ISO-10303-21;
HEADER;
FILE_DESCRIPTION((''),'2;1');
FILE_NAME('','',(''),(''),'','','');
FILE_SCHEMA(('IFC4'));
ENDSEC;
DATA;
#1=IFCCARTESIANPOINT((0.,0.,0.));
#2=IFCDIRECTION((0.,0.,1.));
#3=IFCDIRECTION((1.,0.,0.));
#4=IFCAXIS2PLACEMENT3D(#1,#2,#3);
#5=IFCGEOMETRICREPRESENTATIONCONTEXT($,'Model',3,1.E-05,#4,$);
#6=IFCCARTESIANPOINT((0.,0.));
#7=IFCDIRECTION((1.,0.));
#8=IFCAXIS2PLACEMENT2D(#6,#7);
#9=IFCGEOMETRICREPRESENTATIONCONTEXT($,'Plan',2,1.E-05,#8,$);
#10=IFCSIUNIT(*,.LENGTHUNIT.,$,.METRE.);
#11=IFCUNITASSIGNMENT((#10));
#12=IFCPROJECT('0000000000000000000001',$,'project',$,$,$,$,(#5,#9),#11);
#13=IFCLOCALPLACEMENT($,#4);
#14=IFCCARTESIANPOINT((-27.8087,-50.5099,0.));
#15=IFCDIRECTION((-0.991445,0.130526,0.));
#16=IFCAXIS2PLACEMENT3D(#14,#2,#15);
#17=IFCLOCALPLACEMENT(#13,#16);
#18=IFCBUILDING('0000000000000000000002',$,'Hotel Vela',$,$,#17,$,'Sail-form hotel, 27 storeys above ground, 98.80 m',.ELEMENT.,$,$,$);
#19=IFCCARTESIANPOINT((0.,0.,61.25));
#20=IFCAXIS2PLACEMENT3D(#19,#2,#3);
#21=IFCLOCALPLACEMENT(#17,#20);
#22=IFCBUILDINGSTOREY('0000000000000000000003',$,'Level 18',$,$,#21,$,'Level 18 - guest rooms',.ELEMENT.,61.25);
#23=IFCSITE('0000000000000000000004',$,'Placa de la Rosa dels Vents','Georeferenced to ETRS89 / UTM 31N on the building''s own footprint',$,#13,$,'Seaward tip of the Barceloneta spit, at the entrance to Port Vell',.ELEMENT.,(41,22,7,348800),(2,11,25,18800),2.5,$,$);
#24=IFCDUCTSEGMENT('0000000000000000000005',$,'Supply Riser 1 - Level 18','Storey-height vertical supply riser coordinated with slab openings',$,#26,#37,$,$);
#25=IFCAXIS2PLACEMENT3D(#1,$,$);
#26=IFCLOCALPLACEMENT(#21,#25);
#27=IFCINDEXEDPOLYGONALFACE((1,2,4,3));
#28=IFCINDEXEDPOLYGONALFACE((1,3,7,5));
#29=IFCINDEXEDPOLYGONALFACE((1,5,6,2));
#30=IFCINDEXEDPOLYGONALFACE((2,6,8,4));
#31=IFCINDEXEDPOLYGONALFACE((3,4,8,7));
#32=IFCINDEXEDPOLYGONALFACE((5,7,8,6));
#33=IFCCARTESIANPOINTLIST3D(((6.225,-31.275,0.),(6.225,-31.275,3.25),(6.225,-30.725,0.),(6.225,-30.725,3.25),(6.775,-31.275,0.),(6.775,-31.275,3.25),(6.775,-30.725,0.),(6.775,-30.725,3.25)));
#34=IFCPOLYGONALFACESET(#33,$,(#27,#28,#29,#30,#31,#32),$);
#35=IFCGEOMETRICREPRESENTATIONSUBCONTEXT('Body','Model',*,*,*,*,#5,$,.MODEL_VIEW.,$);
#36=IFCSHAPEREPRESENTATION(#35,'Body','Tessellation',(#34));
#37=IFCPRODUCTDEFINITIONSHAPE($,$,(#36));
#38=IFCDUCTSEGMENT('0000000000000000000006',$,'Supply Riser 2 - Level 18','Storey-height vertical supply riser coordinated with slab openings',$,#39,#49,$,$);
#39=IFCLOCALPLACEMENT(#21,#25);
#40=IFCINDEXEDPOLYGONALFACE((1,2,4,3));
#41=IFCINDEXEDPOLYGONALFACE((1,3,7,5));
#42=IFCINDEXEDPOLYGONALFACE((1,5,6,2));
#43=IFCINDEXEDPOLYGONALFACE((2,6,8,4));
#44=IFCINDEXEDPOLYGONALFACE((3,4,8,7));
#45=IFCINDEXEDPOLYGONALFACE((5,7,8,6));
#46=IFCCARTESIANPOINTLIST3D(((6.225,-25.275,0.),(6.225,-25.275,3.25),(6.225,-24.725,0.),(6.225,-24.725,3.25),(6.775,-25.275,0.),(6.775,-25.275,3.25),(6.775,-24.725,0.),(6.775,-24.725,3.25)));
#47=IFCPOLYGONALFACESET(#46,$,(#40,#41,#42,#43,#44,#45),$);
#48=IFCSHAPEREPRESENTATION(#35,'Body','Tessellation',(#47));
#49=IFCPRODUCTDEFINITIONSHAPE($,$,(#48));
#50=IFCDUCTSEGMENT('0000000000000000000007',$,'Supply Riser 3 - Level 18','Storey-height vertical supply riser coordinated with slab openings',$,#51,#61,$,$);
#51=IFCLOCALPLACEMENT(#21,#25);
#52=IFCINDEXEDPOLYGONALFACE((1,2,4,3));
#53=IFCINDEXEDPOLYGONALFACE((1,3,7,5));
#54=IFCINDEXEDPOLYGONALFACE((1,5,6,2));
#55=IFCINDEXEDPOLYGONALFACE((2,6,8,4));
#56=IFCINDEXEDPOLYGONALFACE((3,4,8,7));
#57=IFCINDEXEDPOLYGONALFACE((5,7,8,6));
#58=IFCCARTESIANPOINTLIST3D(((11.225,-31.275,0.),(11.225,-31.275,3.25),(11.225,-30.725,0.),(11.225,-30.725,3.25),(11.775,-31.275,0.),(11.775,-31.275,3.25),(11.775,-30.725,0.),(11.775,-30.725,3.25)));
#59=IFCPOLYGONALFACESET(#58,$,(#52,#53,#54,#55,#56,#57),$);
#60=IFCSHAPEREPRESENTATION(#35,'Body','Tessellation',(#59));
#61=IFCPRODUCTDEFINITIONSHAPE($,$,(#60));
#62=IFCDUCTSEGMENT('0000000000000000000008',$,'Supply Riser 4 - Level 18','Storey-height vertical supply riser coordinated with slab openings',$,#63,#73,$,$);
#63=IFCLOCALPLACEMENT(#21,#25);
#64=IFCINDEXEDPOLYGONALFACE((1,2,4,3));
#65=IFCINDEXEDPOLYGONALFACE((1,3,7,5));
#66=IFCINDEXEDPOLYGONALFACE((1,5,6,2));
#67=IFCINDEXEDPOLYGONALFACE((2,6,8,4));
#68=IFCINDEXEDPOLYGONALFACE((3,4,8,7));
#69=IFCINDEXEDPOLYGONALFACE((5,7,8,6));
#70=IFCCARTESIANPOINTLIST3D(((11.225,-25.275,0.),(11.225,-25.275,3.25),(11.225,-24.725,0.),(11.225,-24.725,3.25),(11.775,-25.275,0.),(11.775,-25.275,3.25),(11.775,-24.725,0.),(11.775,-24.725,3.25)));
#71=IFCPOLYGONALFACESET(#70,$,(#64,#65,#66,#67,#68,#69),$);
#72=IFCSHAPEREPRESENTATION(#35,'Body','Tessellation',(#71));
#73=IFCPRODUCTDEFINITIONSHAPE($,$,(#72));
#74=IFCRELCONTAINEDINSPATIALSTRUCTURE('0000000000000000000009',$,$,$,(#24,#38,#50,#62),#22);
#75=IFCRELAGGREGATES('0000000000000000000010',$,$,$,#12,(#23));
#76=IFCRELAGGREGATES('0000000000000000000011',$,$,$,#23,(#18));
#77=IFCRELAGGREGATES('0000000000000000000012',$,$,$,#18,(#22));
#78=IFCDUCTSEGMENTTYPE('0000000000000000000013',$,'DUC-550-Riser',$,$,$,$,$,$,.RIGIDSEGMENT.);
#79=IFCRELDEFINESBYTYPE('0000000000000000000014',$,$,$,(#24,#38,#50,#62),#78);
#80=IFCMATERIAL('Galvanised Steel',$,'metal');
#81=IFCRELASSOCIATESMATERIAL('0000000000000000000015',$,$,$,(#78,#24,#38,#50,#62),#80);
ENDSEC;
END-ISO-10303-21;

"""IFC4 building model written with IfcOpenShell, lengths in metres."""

from ifc_helpers import new_model, si_unit, frame, origin_with_axes, origin_2d_with_axis, place, context, subcontext, project, spatial, line, indexed_curve, outline, extrude, material, type_object, element, save


model = new_model("IFC4")

# Units and contexts
model_context = context("Model", 3, precision=1e-05, world=origin_with_axes())
plan_context = context("Plan", 2, precision=1e-05, world=origin_2d_with_axis())
body_context = subcontext(model_context, "Body", "Model", "MODEL_VIEW")
ifc_project = project(units=[si_unit("LENGTHUNIT", "METRE")], contexts=[model_context, plan_context])

# Site, building, storey
site_placement = place(None, origin_with_axes())
site = spatial("IfcSite", under=ifc_project, at=site_placement, Name="Placa de la Rosa dels Vents", Description="Georeferenced to ETRS89 / UTM 31N on the building's own footprint", LongName="Seaward tip of the Barceloneta spit, at the entrance to Port Vell", CompositionType="ELEMENT", RefLatitude=(41, 22, 7, 348800), RefLongitude=(2, 11, 25, 18800), RefElevation=2.5)
building_placement = place(site_placement, frame((-27.8087, -50.5099, 0.0), z_axis=(0.0, 0.0, 1.0), x_axis=(-0.991445, 0.130526, 0.0)))
building = spatial("IfcBuilding", under=site, at=building_placement, Name="Hotel Vela", LongName="Sail-form hotel, 27 storeys above ground, 98.80 m", CompositionType="ELEMENT")
storey_placement = place(building_placement, frame((0.0, 0.0, 61.25), z_axis=(0.0, 0.0, 1.0), x_axis=(1.0, 0.0, 0.0)))
storey = spatial("IfcBuildingStorey", under=building, at=storey_placement, Name="Level 18", LongName="Level 18 - guest rooms", CompositionType="ELEMENT", Elevation=61.25)

# Duct segments
ifc_material = material(Name="Galvanised Steel", Category="metal")
duct_segment_type = type_object("IfcDuctSegmentType", Name="DUC-550-Riser", PredefinedType="RIGIDSEGMENT", material=ifc_material)
for number, where, z_axis, x_axis, name in (
    (1, (6.225, -31.275, 0.0), (0.0, 0.0, 1.0), (1.0, 0.0, 0.0), "Supply Riser 1 - Level 18"),
    (2, (6.225, -25.275, 0.0), (0.0, 0.0, 1.0), (1.0, 0.0, 0.0), "Supply Riser 2 - Level 18"),
    (3, (11.225, -31.275, 0.0), (0.0, 0.0, 1.0), (1.0, 0.0, 0.0), "Supply Riser 3 - Level 18"),
    (4, (11.225, -25.275, 0.0), (0.0, 0.0, 1.0), (1.0, 0.0, 0.0), "Supply Riser 4 - Level 18"),
):
    element("IfcDuctSegment", number, at=place(storey_placement, frame(where, z_axis=z_axis, x_axis=x_axis)), inside=storey, type_object=duct_segment_type, material=ifc_material, Name=name, Description="Storey-height vertical supply riser coordinated with slab openings", context=body_context, shape_type="SweptSolid", body=[
        extrude(outline(indexed_curve([(0.0, 0.0), (0.55, 0.0), (0.55, 0.55), (0.0, 0.55)], segments=[line(1, 2, 3, 4, 1)])), origin_with_axes(), (0.0, 0.0, 1.0), 3.25),
    ])

save(model, "model.ifc")
